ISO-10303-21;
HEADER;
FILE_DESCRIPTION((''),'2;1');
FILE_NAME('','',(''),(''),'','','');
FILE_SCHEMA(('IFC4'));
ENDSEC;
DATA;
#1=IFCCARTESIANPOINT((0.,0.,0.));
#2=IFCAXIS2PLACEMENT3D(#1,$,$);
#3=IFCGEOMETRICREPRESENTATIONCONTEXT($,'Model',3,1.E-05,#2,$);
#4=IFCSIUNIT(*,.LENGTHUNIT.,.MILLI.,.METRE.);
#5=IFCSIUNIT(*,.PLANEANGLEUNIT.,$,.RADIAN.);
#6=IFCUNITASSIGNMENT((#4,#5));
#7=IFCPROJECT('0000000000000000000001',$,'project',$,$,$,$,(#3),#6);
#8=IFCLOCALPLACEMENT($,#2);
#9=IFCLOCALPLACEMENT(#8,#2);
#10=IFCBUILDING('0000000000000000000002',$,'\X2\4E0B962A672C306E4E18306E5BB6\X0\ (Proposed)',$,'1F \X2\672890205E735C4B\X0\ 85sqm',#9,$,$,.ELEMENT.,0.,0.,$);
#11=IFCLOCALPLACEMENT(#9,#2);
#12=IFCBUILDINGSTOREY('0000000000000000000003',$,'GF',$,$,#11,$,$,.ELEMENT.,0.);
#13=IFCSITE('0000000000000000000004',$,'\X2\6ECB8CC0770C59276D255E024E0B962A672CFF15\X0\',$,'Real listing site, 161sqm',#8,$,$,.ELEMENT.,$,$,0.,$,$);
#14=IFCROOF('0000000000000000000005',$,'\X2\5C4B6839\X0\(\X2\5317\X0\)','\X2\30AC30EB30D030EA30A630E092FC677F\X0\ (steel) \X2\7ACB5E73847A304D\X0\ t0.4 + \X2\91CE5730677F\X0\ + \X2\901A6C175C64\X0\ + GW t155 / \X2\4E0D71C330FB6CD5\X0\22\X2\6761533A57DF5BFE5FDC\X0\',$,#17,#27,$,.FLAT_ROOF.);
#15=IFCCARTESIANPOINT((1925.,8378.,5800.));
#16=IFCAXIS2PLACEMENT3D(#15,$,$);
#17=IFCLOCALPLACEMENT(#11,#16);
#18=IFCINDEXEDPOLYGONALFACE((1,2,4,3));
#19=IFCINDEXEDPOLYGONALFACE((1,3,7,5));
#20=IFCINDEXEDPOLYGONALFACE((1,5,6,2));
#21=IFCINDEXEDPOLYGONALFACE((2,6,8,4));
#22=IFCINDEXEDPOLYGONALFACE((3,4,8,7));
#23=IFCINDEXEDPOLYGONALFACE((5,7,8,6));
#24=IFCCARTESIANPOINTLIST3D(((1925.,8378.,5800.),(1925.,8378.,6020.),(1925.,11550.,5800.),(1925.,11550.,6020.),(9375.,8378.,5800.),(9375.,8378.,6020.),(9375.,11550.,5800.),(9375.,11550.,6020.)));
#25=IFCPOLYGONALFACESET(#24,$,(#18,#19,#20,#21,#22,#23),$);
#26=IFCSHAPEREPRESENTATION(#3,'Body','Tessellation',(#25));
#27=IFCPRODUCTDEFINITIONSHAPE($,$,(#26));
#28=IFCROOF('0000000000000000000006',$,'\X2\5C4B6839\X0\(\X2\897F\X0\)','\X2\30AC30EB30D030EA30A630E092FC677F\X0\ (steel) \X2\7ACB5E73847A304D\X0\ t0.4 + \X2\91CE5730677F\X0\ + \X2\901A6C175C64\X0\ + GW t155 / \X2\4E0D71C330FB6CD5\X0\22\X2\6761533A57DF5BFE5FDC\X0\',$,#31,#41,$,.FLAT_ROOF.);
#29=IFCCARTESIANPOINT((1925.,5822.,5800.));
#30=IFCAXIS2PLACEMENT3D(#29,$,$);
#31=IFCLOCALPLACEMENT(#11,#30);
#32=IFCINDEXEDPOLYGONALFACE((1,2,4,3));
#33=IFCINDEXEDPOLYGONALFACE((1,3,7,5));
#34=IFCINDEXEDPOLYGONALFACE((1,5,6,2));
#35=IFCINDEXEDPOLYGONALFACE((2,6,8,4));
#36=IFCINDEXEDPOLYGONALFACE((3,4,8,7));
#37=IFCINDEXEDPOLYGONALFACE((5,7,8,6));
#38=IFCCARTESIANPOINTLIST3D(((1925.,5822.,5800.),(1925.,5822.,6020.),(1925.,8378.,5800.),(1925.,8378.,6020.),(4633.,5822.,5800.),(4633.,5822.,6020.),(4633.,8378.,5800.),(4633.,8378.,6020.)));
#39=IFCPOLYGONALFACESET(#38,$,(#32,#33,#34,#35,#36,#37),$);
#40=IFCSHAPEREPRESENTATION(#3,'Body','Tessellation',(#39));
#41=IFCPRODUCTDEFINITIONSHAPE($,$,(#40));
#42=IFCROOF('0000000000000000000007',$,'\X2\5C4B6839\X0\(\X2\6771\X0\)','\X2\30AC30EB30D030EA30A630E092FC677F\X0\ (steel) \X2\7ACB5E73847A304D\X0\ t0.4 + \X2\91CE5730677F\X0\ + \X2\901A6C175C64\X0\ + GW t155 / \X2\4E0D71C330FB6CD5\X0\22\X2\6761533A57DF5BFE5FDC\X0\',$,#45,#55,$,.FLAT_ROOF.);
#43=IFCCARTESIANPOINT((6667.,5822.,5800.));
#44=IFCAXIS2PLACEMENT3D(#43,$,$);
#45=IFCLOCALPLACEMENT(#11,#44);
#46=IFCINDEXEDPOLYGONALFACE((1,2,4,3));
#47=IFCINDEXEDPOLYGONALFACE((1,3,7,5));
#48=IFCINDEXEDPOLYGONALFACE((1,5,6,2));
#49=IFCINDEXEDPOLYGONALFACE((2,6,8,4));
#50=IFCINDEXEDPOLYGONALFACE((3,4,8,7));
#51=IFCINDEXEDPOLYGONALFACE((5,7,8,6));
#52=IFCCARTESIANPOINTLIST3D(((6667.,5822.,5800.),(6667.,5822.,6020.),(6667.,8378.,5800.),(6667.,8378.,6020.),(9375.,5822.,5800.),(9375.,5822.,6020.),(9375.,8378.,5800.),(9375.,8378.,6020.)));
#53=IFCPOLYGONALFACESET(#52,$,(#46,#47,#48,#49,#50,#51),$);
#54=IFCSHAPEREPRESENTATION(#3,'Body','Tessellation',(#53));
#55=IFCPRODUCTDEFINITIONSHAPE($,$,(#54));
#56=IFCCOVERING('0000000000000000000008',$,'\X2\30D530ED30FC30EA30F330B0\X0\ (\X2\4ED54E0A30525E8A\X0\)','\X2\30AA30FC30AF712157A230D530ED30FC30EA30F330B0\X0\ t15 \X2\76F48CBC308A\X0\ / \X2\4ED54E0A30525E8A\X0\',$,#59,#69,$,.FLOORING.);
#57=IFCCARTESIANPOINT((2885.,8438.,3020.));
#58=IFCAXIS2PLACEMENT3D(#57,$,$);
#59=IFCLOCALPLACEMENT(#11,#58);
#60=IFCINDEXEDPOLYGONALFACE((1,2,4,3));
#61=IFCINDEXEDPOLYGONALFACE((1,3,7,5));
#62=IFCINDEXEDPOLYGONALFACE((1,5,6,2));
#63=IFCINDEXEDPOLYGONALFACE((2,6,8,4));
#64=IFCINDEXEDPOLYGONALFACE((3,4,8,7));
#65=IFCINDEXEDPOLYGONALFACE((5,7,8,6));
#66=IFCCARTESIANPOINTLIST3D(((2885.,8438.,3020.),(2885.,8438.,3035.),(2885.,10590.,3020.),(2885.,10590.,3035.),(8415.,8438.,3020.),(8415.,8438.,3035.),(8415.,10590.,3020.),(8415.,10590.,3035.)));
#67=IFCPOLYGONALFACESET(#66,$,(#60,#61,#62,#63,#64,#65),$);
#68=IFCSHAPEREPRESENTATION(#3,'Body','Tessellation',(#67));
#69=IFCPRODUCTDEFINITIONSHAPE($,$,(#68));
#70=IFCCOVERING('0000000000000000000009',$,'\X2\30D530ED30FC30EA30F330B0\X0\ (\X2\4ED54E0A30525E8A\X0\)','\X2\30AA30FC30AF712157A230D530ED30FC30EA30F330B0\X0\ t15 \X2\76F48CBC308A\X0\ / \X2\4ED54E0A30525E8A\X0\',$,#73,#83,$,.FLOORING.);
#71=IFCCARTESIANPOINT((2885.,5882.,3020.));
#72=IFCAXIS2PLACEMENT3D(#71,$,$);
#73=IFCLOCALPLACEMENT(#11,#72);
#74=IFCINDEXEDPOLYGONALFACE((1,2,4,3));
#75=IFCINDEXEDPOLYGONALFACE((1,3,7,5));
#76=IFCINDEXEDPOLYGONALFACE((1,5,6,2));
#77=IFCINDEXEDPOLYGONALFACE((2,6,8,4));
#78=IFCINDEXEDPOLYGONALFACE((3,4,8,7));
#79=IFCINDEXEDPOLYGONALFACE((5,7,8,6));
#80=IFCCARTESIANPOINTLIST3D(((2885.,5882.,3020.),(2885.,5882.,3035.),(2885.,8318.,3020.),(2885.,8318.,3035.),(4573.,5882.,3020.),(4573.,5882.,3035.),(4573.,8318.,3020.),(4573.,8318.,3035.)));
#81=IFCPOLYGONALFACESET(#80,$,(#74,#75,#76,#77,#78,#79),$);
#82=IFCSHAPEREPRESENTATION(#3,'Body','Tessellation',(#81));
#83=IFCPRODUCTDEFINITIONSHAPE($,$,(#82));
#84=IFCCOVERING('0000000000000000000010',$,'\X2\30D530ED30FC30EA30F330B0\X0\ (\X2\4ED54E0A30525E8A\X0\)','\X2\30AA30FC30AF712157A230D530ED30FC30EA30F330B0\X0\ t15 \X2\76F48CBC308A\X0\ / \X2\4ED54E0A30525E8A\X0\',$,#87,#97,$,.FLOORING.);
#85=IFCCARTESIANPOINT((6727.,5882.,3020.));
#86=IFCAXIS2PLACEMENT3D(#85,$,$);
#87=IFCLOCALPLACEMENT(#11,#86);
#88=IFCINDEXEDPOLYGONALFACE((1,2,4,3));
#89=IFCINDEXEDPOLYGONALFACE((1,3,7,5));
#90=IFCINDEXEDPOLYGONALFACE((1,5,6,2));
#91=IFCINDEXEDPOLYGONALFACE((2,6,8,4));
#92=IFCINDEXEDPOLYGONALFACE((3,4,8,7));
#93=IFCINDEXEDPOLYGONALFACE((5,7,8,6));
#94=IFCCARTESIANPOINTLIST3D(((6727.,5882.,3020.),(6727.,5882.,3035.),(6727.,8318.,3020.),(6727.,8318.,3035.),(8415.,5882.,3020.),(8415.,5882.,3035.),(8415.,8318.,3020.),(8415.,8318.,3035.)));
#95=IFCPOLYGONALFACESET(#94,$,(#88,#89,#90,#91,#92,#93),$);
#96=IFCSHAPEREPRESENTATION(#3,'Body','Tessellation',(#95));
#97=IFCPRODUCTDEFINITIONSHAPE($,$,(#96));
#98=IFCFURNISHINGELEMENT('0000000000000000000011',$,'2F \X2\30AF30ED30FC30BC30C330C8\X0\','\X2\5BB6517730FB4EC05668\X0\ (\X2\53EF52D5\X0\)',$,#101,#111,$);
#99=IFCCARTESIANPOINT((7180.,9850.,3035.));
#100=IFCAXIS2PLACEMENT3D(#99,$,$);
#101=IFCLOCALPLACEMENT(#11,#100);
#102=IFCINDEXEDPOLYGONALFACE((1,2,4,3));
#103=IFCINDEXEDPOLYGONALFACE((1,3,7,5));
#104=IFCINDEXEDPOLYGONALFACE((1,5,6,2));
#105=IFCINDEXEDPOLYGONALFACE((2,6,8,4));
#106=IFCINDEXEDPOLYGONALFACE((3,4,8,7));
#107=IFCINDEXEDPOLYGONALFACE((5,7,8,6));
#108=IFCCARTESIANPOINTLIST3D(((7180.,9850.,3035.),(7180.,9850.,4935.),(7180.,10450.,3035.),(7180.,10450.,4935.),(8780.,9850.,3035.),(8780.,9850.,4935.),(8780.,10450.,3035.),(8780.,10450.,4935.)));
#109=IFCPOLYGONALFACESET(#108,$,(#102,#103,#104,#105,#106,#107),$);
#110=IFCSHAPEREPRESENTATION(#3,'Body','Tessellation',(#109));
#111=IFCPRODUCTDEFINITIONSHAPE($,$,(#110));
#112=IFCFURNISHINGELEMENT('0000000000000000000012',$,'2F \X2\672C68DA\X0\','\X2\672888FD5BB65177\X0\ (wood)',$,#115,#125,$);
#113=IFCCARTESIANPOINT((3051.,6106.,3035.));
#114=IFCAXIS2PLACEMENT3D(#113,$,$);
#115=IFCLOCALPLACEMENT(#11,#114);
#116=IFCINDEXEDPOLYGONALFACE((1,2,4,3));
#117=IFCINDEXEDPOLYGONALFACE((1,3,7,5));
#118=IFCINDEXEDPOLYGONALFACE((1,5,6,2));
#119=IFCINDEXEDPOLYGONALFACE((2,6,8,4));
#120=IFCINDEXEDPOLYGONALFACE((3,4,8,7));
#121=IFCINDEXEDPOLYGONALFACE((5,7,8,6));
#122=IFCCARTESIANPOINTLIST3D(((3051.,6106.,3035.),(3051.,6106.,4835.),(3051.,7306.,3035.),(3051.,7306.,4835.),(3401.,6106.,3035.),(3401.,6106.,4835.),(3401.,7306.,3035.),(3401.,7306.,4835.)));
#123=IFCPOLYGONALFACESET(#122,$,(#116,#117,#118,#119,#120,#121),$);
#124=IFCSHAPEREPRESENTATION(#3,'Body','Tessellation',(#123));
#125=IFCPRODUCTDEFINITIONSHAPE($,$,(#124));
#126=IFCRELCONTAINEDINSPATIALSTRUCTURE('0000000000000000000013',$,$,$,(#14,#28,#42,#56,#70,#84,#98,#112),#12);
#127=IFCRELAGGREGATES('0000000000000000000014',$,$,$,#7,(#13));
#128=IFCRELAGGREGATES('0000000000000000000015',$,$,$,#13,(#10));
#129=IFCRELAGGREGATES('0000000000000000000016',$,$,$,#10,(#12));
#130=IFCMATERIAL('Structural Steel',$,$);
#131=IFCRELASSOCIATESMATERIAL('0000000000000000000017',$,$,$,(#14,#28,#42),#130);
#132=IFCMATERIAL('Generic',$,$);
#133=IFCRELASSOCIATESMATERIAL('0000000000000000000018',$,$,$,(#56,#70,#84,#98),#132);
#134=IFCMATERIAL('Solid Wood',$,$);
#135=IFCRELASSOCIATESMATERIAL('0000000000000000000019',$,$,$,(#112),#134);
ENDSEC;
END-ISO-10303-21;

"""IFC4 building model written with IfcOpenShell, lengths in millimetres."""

from ifc_helpers import new_model, si_unit, frame, frame_2d, origin, place, context, project, spatial, rectangle, extrude, material, element, save


model = new_model("IFC4")

# Units and contexts
model_context = context("Model", 3, precision=1e-05, world=origin())
ifc_project = project(units=[si_unit("LENGTHUNIT", "METRE", prefix="MILLI"), si_unit("PLANEANGLEUNIT", "RADIAN")], contexts=[model_context])

# Site, building, storey
site_placement = place(None, origin())
site = spatial("IfcSite", under=ifc_project, at=site_placement, Name="滋賀県大津市下阪本５", ObjectType="Real listing site, 161sqm", CompositionType="ELEMENT", RefElevation=0.0)
building_placement = place(site_placement, origin())
building = spatial("IfcBuilding", under=site, at=building_placement, Name="下阪本の丘の家 (Proposed)", ObjectType="1F 木造平屋 85sqm", CompositionType="ELEMENT", ElevationOfRefHeight=0.0, ElevationOfTerrain=0.0)
storey_placement = place(building_placement, origin())
storey = spatial("IfcBuildingStorey", under=building, at=storey_placement, Name="GF", CompositionType="ELEMENT", Elevation=0.0)

# Shared definitions
ifc_material_1 = material(Name="Solid Wood")

# Shared definitions
ifc_material_2 = material(Name="Generic")

# Roofs
ifc_material_3 = material(Name="Structural Steel")
for number, where, name in (
    (1, (1925.0, 8378.0, 5800.0), "屋根(北)"),
):
    element("IfcRoof", number, at=place(storey_placement, frame(where)), inside=storey, material=ifc_material_3, Name=name, Description="ガルバリウム鋼板 (steel) 立平葺き t0.4 + 野地板 + 通気層 + GW t155 / 不燃・法22条区域対応", PredefinedType="FLAT_ROOF", context=model_context, shape_type="SweptSolid", body=[
        extrude(rectangle(XDim=7450.0, YDim=3172.0, at=frame_2d((3725.0, 1586.0))), frame((1925.0, 8378.0, 5800.0)), (0.0, 0.0, 1.0), 220.0),
    ])
roof_1_placement = place(storey_placement, frame((1925.0, 5822.0, 5800.0)))
element("IfcRoof", 2, at=roof_1_placement, inside=storey, material=ifc_material_3, Name="屋根(西)", Description="ガルバリウム鋼板 (steel) 立平葺き t0.4 + 野地板 + 通気層 + GW t155 / 不燃・法22条区域対応", PredefinedType="FLAT_ROOF", context=model_context, shape_type="SweptSolid", body=[
    extrude(rectangle(XDim=2708.0, YDim=2556.0, at=frame_2d((1354.0, 1278.0))), frame((1925.0, 5822.0, 5800.0)), (0.0, 0.0, 1.0), 220.0),
])
roof_2_placement = place(storey_placement, frame((6667.0, 5822.0, 5800.0)))
element("IfcRoof", 3, at=roof_2_placement, inside=storey, material=ifc_material_3, Name="屋根(東)", Description="ガルバリウム鋼板 (steel) 立平葺き t0.4 + 野地板 + 通気層 + GW t155 / 不燃・法22条区域対応", PredefinedType="FLAT_ROOF", context=model_context, shape_type="SweptSolid", body=[
    extrude(rectangle(XDim=2708.0, YDim=2556.0, at=frame_2d((1354.0, 1278.0))), frame((6667.0, 5822.0, 5800.0)), (0.0, 0.0, 1.0), 220.0),
])

# Coverings
covering_1_placement = place(storey_placement, frame((2885.0, 8438.0, 3020.0)))
element("IfcCovering", 4, at=covering_1_placement, inside=storey, material=ifc_material_2, Name="フローリング (仕上げ床)", Description="オーク無垢フローリング t15 直貼り / 仕上げ床", PredefinedType="FLOORING", context=model_context, shape_type="SweptSolid", body=[
    extrude(rectangle(XDim=5530.0, YDim=2152.0, at=frame_2d((2765.0, 1076.0))), frame((2885.0, 8438.0, 3020.0)), (0.0, 0.0, 1.0), 15.0),
])
covering_2_placement = place(storey_placement, frame((2885.0, 5882.0, 3020.0)))
element("IfcCovering", 5, at=covering_2_placement, inside=storey, material=ifc_material_2, Name="フローリング (仕上げ床)", Description="オーク無垢フローリング t15 直貼り / 仕上げ床", PredefinedType="FLOORING", context=model_context, shape_type="SweptSolid", body=[
    extrude(rectangle(XDim=1688.0, YDim=2436.0, at=frame_2d((844.0, 1218.0))), frame((2885.0, 5882.0, 3020.0)), (0.0, 0.0, 1.0), 15.0),
])
covering_3_placement = place(storey_placement, frame((6727.0, 5882.0, 3020.0)))
element("IfcCovering", 6, at=covering_3_placement, inside=storey, material=ifc_material_2, Name="フローリング (仕上げ床)", Description="オーク無垢フローリング t15 直貼り / 仕上げ床", PredefinedType="FLOORING", context=model_context, shape_type="SweptSolid", body=[
    extrude(rectangle(XDim=1688.0, YDim=2436.0, at=frame_2d((844.0, 1218.0))), frame((6727.0, 5882.0, 3020.0)), (0.0, 0.0, 1.0), 15.0),
])

# Furnishing elements
furnishing_1_placement = place(storey_placement, frame((7180.0, 9850.0, 3035.0)))
element("IfcFurnishingElement", 7, at=furnishing_1_placement, inside=storey, material=ifc_material_2, Name="2F クローゼット", Description="家具・什器 (可動)", context=model_context, shape_type="SweptSolid", body=[
    extrude(rectangle(XDim=1600.0, YDim=600.0, at=frame_2d((800.0, 300.0))), frame((7180.0, 9850.0, 3035.0)), (0.0, 0.0, 1.0), 1900.0),
])
furnishing_2_placement = place(storey_placement, frame((3051.0, 6106.0, 3035.0)))
element("IfcFurnishingElement", 8, at=furnishing_2_placement, inside=storey, material=ifc_material_1, Name="2F 本棚", Description="木製家具 (wood)", context=model_context, shape_type="SweptSolid", body=[
    extrude(rectangle(XDim=350.0, YDim=1200.0, at=frame_2d((175.0, 600.0))), frame((3051.0, 6106.0, 3035.0)), (0.0, 0.0, 1.0), 1800.0),
])

save(model, "model.ifc")
